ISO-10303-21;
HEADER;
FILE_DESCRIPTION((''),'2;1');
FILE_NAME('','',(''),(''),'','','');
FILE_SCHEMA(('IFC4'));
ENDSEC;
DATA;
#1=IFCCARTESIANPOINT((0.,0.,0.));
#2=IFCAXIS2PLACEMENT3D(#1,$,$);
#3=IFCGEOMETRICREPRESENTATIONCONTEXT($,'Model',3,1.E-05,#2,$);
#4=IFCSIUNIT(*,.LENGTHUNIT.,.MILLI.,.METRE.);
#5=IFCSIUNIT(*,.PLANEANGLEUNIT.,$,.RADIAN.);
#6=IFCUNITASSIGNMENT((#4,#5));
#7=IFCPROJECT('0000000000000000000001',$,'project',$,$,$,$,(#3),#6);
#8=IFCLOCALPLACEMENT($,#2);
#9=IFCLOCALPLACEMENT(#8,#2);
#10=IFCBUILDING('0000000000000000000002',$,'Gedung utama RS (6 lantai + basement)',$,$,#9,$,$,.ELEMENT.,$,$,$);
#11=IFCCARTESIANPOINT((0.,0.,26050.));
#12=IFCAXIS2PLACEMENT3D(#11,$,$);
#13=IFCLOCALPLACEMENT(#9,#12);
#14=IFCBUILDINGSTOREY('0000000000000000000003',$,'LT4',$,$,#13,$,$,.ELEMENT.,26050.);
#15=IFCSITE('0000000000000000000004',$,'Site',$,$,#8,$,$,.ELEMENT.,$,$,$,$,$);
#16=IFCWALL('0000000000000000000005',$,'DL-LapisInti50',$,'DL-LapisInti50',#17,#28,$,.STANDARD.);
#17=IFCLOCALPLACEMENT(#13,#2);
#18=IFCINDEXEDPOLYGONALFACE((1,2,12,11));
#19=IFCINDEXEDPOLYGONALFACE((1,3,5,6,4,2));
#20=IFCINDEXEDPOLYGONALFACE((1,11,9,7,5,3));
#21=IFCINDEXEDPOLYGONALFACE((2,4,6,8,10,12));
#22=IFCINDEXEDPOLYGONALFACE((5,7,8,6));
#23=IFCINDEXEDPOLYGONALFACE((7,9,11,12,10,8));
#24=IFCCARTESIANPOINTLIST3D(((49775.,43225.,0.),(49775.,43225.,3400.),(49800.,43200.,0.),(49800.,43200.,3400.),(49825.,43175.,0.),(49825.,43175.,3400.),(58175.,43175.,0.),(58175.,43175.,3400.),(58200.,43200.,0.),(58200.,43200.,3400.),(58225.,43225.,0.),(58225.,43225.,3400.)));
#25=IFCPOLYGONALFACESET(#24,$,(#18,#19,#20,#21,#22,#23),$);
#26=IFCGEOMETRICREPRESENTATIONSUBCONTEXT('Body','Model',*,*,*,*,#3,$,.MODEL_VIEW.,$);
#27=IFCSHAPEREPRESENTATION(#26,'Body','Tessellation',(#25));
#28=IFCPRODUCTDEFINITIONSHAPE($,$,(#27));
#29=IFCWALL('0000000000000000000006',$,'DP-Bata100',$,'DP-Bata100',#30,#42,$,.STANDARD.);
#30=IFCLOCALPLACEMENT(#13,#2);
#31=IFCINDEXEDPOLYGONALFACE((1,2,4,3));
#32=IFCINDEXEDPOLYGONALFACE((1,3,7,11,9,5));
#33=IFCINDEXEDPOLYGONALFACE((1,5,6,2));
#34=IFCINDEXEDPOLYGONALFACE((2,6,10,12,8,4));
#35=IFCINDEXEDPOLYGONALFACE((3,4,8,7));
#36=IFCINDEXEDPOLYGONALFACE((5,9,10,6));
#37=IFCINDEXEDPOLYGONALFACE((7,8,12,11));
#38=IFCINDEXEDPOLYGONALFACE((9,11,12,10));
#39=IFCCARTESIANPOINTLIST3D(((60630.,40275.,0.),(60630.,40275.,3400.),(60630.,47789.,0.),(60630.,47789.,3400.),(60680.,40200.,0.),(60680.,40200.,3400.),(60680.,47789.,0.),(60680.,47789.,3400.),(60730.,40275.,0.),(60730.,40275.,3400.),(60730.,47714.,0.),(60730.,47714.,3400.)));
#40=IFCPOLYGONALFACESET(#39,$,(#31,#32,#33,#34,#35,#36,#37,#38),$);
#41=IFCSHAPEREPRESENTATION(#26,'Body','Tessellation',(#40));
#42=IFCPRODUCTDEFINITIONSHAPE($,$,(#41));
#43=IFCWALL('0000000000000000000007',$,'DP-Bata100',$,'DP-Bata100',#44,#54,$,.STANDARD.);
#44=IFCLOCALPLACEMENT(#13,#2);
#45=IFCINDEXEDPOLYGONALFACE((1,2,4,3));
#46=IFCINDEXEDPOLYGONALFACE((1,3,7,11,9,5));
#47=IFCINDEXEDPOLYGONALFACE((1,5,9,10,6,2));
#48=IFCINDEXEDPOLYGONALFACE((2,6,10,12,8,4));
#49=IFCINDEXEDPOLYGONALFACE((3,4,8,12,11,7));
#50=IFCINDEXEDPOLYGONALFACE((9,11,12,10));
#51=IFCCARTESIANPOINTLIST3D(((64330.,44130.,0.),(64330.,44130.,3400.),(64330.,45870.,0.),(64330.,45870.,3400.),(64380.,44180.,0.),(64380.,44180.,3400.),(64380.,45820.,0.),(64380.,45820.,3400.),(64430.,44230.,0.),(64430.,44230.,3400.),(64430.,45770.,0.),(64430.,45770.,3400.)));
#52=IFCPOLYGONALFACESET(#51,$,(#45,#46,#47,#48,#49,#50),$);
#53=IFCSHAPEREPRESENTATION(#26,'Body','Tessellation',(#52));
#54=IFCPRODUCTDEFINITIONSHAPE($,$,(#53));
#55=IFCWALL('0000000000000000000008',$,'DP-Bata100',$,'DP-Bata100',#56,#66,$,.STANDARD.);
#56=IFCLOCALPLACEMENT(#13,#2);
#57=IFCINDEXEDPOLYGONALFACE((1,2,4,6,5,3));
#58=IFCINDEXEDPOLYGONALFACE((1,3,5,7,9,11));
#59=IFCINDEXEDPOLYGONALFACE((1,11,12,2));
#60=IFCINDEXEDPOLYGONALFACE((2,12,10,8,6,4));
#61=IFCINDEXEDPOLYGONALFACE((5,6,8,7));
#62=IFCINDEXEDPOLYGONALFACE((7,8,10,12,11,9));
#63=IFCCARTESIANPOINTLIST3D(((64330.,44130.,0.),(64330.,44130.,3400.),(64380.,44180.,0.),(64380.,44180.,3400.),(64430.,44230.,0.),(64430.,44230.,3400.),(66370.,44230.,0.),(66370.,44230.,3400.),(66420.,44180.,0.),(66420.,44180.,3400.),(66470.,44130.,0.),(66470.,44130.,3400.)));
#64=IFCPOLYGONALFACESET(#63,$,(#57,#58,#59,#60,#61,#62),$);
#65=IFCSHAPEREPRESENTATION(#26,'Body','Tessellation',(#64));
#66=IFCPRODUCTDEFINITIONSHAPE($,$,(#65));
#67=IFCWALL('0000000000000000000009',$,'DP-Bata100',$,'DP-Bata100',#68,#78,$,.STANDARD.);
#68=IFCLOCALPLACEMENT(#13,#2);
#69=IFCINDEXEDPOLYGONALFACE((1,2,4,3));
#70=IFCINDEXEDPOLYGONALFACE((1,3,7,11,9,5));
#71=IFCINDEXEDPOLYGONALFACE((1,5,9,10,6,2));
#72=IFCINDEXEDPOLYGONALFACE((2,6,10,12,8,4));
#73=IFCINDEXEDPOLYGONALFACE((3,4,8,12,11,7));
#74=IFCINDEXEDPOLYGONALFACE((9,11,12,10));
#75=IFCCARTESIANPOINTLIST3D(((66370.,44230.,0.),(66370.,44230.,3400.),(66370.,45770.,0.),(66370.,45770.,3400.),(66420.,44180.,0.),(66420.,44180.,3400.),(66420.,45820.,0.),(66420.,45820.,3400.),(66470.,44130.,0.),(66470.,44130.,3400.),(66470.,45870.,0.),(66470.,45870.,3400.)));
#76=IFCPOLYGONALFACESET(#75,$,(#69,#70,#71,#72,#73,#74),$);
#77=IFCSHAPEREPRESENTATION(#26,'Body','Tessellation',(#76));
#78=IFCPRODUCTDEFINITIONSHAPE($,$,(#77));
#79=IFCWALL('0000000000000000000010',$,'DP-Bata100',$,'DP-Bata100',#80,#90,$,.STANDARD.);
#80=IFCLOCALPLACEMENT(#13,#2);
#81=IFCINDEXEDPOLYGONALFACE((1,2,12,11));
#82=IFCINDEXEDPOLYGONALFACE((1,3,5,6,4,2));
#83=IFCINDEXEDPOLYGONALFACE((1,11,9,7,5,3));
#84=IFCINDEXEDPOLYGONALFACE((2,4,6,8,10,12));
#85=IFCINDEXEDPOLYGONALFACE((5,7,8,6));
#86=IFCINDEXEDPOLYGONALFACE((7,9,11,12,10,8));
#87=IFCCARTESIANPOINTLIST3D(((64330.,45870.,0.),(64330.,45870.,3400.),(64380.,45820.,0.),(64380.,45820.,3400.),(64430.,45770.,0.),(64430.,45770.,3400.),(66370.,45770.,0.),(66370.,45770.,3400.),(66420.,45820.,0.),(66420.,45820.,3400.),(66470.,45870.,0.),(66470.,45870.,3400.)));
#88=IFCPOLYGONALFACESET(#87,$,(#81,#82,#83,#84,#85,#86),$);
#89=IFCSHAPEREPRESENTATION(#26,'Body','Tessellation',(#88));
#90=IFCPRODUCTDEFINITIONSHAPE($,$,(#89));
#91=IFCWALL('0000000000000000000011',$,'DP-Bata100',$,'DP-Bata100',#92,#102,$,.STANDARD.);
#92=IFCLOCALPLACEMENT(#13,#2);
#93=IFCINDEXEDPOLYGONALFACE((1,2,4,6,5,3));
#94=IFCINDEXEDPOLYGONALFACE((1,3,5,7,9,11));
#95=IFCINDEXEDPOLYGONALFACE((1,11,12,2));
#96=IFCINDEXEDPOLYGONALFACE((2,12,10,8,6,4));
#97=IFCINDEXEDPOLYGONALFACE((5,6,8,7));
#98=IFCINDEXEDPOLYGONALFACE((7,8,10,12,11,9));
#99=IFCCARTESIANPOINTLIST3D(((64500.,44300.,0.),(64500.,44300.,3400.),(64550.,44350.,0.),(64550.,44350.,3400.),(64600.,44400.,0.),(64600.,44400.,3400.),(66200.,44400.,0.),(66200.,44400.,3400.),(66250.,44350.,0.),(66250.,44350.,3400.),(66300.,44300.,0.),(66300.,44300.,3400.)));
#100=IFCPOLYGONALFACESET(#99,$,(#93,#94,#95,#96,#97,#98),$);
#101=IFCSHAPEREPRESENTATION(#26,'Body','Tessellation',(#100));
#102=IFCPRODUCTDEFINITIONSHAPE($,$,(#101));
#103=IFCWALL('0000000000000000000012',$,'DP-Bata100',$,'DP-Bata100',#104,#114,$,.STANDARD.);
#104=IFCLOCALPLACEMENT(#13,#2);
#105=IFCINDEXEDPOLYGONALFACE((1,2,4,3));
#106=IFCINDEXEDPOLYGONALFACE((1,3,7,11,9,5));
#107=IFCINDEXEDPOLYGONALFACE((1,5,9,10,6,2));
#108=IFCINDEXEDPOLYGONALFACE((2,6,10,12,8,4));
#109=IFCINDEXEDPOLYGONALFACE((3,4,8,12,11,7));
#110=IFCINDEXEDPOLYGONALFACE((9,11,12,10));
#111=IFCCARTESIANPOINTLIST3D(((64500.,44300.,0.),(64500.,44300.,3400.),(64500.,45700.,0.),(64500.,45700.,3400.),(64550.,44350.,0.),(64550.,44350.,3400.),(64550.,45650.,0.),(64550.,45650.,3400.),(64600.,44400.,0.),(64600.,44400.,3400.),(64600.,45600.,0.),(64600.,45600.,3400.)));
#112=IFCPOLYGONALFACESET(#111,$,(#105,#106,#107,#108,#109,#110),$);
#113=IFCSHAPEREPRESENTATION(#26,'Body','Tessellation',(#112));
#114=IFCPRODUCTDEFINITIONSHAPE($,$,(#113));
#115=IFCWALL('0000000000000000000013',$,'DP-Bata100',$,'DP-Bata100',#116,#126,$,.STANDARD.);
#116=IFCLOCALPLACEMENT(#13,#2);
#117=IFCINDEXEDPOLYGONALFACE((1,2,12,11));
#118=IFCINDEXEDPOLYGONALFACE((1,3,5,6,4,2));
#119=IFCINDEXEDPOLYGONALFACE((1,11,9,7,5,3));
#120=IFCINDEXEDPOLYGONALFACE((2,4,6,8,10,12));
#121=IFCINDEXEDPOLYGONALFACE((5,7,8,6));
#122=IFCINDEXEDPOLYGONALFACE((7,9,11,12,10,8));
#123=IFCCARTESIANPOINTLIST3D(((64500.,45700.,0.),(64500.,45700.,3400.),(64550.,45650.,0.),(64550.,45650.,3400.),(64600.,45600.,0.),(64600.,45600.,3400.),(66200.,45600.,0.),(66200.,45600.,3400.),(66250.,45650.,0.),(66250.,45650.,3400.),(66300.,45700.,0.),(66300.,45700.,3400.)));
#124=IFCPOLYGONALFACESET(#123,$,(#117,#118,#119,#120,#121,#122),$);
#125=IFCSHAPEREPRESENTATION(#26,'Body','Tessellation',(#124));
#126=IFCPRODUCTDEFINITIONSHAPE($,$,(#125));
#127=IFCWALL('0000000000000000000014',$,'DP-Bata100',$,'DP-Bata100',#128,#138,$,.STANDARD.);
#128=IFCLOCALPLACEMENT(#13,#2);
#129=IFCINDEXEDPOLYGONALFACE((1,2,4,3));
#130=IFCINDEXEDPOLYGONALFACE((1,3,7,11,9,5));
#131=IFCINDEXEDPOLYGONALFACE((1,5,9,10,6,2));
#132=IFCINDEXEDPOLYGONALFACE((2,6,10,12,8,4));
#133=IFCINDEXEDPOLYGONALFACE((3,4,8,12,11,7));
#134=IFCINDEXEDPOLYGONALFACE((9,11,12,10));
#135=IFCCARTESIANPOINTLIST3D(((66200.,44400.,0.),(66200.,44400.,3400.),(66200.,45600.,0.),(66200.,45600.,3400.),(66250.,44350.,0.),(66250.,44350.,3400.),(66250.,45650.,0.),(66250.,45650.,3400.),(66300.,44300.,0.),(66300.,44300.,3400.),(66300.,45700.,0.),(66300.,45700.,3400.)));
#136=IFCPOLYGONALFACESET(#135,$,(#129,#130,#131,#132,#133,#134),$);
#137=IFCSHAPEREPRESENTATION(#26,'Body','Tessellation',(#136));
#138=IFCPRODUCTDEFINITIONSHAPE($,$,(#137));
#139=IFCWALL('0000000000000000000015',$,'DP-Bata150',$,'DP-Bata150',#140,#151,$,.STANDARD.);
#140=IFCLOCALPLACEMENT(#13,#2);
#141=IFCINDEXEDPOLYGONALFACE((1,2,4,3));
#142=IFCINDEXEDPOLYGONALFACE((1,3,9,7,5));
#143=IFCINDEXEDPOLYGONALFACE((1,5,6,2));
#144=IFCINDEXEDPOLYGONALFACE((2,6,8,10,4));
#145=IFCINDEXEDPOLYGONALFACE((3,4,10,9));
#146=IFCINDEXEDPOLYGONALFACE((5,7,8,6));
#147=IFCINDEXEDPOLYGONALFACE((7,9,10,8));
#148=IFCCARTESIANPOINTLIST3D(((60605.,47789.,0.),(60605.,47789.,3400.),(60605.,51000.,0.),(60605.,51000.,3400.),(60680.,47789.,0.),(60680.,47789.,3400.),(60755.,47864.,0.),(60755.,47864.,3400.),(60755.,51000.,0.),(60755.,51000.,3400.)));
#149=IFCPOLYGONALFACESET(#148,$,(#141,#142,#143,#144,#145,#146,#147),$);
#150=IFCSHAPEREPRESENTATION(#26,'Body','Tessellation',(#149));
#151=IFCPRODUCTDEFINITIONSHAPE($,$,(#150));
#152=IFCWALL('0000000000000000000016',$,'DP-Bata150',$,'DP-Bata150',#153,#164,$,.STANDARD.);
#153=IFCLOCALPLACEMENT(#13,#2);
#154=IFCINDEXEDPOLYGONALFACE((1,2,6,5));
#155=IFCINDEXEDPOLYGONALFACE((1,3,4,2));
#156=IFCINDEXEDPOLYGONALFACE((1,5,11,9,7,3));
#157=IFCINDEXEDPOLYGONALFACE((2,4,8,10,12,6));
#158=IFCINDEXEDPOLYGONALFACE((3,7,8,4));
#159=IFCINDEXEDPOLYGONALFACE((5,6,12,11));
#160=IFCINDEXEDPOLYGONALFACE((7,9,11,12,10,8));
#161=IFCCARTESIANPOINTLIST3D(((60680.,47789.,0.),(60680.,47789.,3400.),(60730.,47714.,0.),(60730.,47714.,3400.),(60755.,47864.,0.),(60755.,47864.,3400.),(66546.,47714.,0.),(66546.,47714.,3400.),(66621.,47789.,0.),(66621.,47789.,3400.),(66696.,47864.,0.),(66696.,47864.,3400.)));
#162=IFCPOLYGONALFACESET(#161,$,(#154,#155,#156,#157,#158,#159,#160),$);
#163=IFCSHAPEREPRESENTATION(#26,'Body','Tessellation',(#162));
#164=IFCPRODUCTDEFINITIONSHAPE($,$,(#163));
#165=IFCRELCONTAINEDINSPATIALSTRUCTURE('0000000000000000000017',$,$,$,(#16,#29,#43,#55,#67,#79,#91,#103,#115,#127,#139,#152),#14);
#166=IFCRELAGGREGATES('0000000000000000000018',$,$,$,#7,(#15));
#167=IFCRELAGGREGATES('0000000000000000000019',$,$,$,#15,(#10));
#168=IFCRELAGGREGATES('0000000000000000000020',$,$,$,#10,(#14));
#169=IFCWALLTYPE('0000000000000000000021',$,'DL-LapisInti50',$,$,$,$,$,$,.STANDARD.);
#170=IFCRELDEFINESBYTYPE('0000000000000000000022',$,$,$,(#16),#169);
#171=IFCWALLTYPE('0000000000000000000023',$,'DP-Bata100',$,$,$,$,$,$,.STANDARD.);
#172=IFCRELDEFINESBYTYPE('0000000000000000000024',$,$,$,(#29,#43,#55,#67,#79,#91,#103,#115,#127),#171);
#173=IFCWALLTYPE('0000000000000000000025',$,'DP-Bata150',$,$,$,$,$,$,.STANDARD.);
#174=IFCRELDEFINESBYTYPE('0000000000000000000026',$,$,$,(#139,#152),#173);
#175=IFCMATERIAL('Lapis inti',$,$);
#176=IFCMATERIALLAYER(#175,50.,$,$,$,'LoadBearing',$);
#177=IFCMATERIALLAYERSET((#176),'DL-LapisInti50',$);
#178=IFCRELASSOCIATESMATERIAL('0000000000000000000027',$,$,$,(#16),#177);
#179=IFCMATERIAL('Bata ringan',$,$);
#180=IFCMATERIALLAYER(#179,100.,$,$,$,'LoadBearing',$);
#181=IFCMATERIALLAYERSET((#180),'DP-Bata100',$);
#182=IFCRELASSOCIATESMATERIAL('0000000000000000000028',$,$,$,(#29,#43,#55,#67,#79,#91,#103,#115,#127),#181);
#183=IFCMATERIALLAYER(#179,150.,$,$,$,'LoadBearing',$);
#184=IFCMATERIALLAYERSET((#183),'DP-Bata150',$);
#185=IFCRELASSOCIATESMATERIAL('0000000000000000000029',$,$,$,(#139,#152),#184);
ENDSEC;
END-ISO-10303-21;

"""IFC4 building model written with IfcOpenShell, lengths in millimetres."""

from ifc_helpers import new_model, si_unit, frame, origin, place, context, subcontext, project, spatial, polyline, outline, extrude, material, layer, layer_set, layer_usage, type_object, element, save


model = new_model("IFC4")

# Units and contexts
model_context = context("Model", 3, precision=1e-05, world=origin())
body_context = subcontext(model_context, "Body", "Model", "MODEL_VIEW")
ifc_project = project(units=[si_unit("LENGTHUNIT", "METRE", prefix="MILLI"), si_unit("PLANEANGLEUNIT", "RADIAN")], contexts=[model_context])

# Site, building, storey
site_placement = place(None, origin())
site = spatial("IfcSite", under=ifc_project, at=site_placement, Name="Site", CompositionType="ELEMENT")
building_placement = place(site_placement, origin())
building = spatial("IfcBuilding", under=site, at=building_placement, Name="Gedung utama RS (6 lantai + basement)", CompositionType="ELEMENT")
storey_placement = place(building_placement, frame((0.0, 0.0, 26050.0)))
storey = spatial("IfcBuildingStorey", under=building, at=storey_placement, Name="LT4", CompositionType="ELEMENT", Elevation=26050.0)

# Walls
ifc_material_1 = material(Name="Lapis inti")
ifc_layer_1 = layer(ifc_material_1, 50.0, Category="LoadBearing")
ifc_layer_set_1 = layer_set([ifc_layer_1], Name="DL-LapisInti50")
ifc_layer_usage_1 = layer_usage(ifc_layer_set_1, "AXIS2", "NEGATIVE", 25.0)
wall_type_1 = type_object("IfcWallType", Name="DL-LapisInti50", PredefinedType="STANDARD")
wall_1_placement = place(storey_placement, frame((58200.0, 43200.0, 0.0), z_axis=(0.0, 0.0, 1.0), x_axis=(-1.0, 0.0, 0.0)))
element("IfcWall", 1, at=wall_1_placement, inside=storey, type_object=wall_type_1, material=ifc_layer_usage_1, Name="DL-LapisInti50", ObjectType="DL-LapisInti50", PredefinedType="STANDARD", context=body_context, shape_type="SweptSolid", body=[
    extrude(outline(polyline([(-25.0, -25.0), (0.0, 0.0), (25.0, 25.0), (8375.0, 25.0), (8400.0, 0.0), (8425.0, -25.0), (-25.0, -25.0)])), origin(), (0.0, 0.0, 1.0), 3400.0),
])
ifc_material_2 = material(Name="Bata ringan")
ifc_layer_2 = layer(ifc_material_2, 100.0, Category="LoadBearing")
ifc_layer_set_2 = layer_set([ifc_layer_2], Name="DP-Bata100")
ifc_layer_usage_2 = layer_usage(ifc_layer_set_2, "AXIS2", "NEGATIVE", 50.0)
wall_type_2 = type_object("IfcWallType", Name="DP-Bata100", PredefinedType="STANDARD")
wall_2_placement = place(storey_placement, frame((60680.0, 47789.0, 0.0), z_axis=(0.0, 0.0, 1.0), x_axis=(0.0, -1.0, 0.0)))
element("IfcWall", 2, at=wall_2_placement, inside=storey, type_object=wall_type_2, material=ifc_layer_usage_2, Name="DP-Bata100", ObjectType="DP-Bata100", PredefinedType="STANDARD", context=body_context, shape_type="SweptSolid", body=[
    extrude(outline(polyline([(0.0, -50.0), (0.0, 0.0), (75.0, 50.0), (7514.0, 50.0), (7589.0, 0.0), (7514.0, -50.0), (0.0, -50.0)])), origin(), (0.0, 0.0, 1.0), 3400.0),
])
wall_3_placement = place(storey_placement, frame((64380.0, 45820.0, 0.0), z_axis=(0.0, 0.0, 1.0), x_axis=(0.0, -1.0, 0.0)))
element("IfcWall", 3, at=wall_3_placement, inside=storey, type_object=wall_type_2, material=ifc_layer_usage_2, Name="DP-Bata100", ObjectType="DP-Bata100", PredefinedType="STANDARD", context=body_context, shape_type="SweptSolid", body=[
    extrude(outline(polyline([(-50.0, -50.0), (0.0, 0.0), (50.0, 50.0), (1590.0, 50.0), (1640.0, 0.0), (1690.0, -50.0), (-50.0, -50.0)])), origin(), (0.0, 0.0, 1.0), 3400.0),
])
wall_4_placement = place(storey_placement, frame((64380.0, 44180.0, 0.0), z_axis=(0.0, 0.0, 1.0), x_axis=(1.0, 0.0, 0.0)))
element("IfcWall", 4, at=wall_4_placement, inside=storey, type_object=wall_type_2, material=ifc_layer_usage_2, Name="DP-Bata100", ObjectType="DP-Bata100", PredefinedType="STANDARD", context=body_context, shape_type="SweptSolid", body=[
    extrude(outline(polyline([(-50.0, -50.0), (0.0, 0.0), (50.0, 50.0), (1990.0, 50.0), (2040.0, 0.0), (2090.0, -50.0), (-50.0, -50.0)])), origin(), (0.0, 0.0, 1.0), 3400.0),
])
wall_5_placement = place(storey_placement, frame((66420.0, 44180.0, 0.0), z_axis=(0.0, 0.0, 1.0), x_axis=(0.0, 1.0, 0.0)))
element("IfcWall", 5, at=wall_5_placement, inside=storey, type_object=wall_type_2, material=ifc_layer_usage_2, Name="DP-Bata100", ObjectType="DP-Bata100", PredefinedType="STANDARD", context=body_context, shape_type="SweptSolid", body=[
    extrude(outline(polyline([(-50.0, -50.0), (0.0, 0.0), (50.0, 50.0), (1590.0, 50.0), (1640.0, 0.0), (1690.0, -50.0), (-50.0, -50.0)])), origin(), (0.0, 0.0, 1.0), 3400.0),
])
wall_6_placement = place(storey_placement, frame((66420.0, 45820.0, 0.0), z_axis=(0.0, 0.0, 1.0), x_axis=(-1.0, 0.0, 0.0)))
element("IfcWall", 6, at=wall_6_placement, inside=storey, type_object=wall_type_2, material=ifc_layer_usage_2, Name="DP-Bata100", ObjectType="DP-Bata100", PredefinedType="STANDARD", context=body_context, shape_type="SweptSolid", body=[
    extrude(outline(polyline([(-50.0, -50.0), (0.0, 0.0), (50.0, 50.0), (1990.0, 50.0), (2040.0, 0.0), (2090.0, -50.0), (-50.0, -50.0)])), origin(), (0.0, 0.0, 1.0), 3400.0),
])
wall_7_placement = place(storey_placement, frame((66250.0, 44350.0, 0.0), z_axis=(0.0, 0.0, 1.0), x_axis=(-1.0, 0.0, 0.0)))
element("IfcWall", 7, at=wall_7_placement, inside=storey, type_object=wall_type_2, material=ifc_layer_usage_2, Name="DP-Bata100", ObjectType="DP-Bata100", PredefinedType="STANDARD", context=body_context, shape_type="SweptSolid", body=[
    extrude(outline(polyline([(50.0, -50.0), (0.0, 0.0), (-50.0, 50.0), (1750.0, 50.0), (1700.0, 0.0), (1650.0, -50.0), (50.0, -50.0)])), origin(), (0.0, 0.0, 1.0), 3400.0),
])
wall_8_placement = place(storey_placement, frame((64550.0, 44350.0, 0.0), z_axis=(0.0, 0.0, 1.0), x_axis=(0.0, 1.0, 0.0)))
element("IfcWall", 8, at=wall_8_placement, inside=storey, type_object=wall_type_2, material=ifc_layer_usage_2, Name="DP-Bata100", ObjectType="DP-Bata100", PredefinedType="STANDARD", context=body_context, shape_type="SweptSolid", body=[
    extrude(outline(polyline([(50.0, -50.0), (0.0, 0.0), (-50.0, 50.0), (1350.0, 50.0), (1300.0, 0.0), (1250.0, -50.0), (50.0, -50.0)])), origin(), (0.0, 0.0, 1.0), 3400.0),
])
wall_9_placement = place(storey_placement, frame((64550.0, 45650.0, 0.0), z_axis=(0.0, 0.0, 1.0), x_axis=(1.0, 0.0, 0.0)))
element("IfcWall", 9, at=wall_9_placement, inside=storey, type_object=wall_type_2, material=ifc_layer_usage_2, Name="DP-Bata100", ObjectType="DP-Bata100", PredefinedType="STANDARD", context=body_context, shape_type="SweptSolid", body=[
    extrude(outline(polyline([(50.0, -50.0), (0.0, 0.0), (-50.0, 50.0), (1750.0, 50.0), (1700.0, 0.0), (1650.0, -50.0), (50.0, -50.0)])), origin(), (0.0, 0.0, 1.0), 3400.0),
])
wall_10_placement = place(storey_placement, frame((66250.0, 45650.0, 0.0), z_axis=(0.0, 0.0, 1.0), x_axis=(0.0, -1.0, 0.0)))
element("IfcWall", 10, at=wall_10_placement, inside=storey, type_object=wall_type_2, material=ifc_layer_usage_2, Name="DP-Bata100", ObjectType="DP-Bata100", PredefinedType="STANDARD", context=body_context, shape_type="SweptSolid", body=[
    extrude(outline(polyline([(50.0, -50.0), (0.0, 0.0), (-50.0, 50.0), (1350.0, 50.0), (1300.0, 0.0), (1250.0, -50.0), (50.0, -50.0)])), origin(), (0.0, 0.0, 1.0), 3400.0),
])
ifc_layer_3 = layer(ifc_material_2, 150.0, Category="LoadBearing")
ifc_layer_set_3 = layer_set([ifc_layer_3], Name="DP-Bata150")
ifc_layer_usage_3 = layer_usage(ifc_layer_set_3, "AXIS2", "NEGATIVE", 75.0)
wall_type_3 = type_object("IfcWallType", Name="DP-Bata150", PredefinedType="STANDARD")
wall_11_placement = place(storey_placement, frame((60680.0, 51000.0, 0.0), z_axis=(0.0, 0.0, 1.0), x_axis=(0.0, -1.0, 0.0)))
element("IfcWall", 11, at=wall_11_placement, inside=storey, type_object=wall_type_3, material=ifc_layer_usage_3, Name="DP-Bata150", ObjectType="DP-Bata150", PredefinedType="STANDARD", context=body_context, shape_type="SweptSolid", body=[
    extrude(outline(polyline([(0.0, -75.0), (0.0, 75.0), (3136.0, 75.0), (3211.0, 0.0), (3211.0, -75.0), (0.0, -75.0)])), origin(), (0.0, 0.0, 1.0), 3400.0),
])
wall_12_placement = place(storey_placement, frame((60680.0, 47789.0, 0.0), z_axis=(0.0, 0.0, 1.0), x_axis=(1.0, 0.0, 0.0)))
element("IfcWall", 12, at=wall_12_placement, inside=storey, type_object=wall_type_3, material=ifc_layer_usage_3, Name="DP-Bata150", ObjectType="DP-Bata150", PredefinedType="STANDARD", context=body_context, shape_type="SweptSolid", body=[
    extrude(outline(polyline([(50.0, -75.0), (0.0, 0.0), (75.0, 75.0), (6016.0, 75.0), (5941.0, 0.0), (5866.0, -75.0), (50.0, -75.0)])), origin(), (0.0, 0.0, 1.0), 3400.0),
])

save(model, "model.ifc")
